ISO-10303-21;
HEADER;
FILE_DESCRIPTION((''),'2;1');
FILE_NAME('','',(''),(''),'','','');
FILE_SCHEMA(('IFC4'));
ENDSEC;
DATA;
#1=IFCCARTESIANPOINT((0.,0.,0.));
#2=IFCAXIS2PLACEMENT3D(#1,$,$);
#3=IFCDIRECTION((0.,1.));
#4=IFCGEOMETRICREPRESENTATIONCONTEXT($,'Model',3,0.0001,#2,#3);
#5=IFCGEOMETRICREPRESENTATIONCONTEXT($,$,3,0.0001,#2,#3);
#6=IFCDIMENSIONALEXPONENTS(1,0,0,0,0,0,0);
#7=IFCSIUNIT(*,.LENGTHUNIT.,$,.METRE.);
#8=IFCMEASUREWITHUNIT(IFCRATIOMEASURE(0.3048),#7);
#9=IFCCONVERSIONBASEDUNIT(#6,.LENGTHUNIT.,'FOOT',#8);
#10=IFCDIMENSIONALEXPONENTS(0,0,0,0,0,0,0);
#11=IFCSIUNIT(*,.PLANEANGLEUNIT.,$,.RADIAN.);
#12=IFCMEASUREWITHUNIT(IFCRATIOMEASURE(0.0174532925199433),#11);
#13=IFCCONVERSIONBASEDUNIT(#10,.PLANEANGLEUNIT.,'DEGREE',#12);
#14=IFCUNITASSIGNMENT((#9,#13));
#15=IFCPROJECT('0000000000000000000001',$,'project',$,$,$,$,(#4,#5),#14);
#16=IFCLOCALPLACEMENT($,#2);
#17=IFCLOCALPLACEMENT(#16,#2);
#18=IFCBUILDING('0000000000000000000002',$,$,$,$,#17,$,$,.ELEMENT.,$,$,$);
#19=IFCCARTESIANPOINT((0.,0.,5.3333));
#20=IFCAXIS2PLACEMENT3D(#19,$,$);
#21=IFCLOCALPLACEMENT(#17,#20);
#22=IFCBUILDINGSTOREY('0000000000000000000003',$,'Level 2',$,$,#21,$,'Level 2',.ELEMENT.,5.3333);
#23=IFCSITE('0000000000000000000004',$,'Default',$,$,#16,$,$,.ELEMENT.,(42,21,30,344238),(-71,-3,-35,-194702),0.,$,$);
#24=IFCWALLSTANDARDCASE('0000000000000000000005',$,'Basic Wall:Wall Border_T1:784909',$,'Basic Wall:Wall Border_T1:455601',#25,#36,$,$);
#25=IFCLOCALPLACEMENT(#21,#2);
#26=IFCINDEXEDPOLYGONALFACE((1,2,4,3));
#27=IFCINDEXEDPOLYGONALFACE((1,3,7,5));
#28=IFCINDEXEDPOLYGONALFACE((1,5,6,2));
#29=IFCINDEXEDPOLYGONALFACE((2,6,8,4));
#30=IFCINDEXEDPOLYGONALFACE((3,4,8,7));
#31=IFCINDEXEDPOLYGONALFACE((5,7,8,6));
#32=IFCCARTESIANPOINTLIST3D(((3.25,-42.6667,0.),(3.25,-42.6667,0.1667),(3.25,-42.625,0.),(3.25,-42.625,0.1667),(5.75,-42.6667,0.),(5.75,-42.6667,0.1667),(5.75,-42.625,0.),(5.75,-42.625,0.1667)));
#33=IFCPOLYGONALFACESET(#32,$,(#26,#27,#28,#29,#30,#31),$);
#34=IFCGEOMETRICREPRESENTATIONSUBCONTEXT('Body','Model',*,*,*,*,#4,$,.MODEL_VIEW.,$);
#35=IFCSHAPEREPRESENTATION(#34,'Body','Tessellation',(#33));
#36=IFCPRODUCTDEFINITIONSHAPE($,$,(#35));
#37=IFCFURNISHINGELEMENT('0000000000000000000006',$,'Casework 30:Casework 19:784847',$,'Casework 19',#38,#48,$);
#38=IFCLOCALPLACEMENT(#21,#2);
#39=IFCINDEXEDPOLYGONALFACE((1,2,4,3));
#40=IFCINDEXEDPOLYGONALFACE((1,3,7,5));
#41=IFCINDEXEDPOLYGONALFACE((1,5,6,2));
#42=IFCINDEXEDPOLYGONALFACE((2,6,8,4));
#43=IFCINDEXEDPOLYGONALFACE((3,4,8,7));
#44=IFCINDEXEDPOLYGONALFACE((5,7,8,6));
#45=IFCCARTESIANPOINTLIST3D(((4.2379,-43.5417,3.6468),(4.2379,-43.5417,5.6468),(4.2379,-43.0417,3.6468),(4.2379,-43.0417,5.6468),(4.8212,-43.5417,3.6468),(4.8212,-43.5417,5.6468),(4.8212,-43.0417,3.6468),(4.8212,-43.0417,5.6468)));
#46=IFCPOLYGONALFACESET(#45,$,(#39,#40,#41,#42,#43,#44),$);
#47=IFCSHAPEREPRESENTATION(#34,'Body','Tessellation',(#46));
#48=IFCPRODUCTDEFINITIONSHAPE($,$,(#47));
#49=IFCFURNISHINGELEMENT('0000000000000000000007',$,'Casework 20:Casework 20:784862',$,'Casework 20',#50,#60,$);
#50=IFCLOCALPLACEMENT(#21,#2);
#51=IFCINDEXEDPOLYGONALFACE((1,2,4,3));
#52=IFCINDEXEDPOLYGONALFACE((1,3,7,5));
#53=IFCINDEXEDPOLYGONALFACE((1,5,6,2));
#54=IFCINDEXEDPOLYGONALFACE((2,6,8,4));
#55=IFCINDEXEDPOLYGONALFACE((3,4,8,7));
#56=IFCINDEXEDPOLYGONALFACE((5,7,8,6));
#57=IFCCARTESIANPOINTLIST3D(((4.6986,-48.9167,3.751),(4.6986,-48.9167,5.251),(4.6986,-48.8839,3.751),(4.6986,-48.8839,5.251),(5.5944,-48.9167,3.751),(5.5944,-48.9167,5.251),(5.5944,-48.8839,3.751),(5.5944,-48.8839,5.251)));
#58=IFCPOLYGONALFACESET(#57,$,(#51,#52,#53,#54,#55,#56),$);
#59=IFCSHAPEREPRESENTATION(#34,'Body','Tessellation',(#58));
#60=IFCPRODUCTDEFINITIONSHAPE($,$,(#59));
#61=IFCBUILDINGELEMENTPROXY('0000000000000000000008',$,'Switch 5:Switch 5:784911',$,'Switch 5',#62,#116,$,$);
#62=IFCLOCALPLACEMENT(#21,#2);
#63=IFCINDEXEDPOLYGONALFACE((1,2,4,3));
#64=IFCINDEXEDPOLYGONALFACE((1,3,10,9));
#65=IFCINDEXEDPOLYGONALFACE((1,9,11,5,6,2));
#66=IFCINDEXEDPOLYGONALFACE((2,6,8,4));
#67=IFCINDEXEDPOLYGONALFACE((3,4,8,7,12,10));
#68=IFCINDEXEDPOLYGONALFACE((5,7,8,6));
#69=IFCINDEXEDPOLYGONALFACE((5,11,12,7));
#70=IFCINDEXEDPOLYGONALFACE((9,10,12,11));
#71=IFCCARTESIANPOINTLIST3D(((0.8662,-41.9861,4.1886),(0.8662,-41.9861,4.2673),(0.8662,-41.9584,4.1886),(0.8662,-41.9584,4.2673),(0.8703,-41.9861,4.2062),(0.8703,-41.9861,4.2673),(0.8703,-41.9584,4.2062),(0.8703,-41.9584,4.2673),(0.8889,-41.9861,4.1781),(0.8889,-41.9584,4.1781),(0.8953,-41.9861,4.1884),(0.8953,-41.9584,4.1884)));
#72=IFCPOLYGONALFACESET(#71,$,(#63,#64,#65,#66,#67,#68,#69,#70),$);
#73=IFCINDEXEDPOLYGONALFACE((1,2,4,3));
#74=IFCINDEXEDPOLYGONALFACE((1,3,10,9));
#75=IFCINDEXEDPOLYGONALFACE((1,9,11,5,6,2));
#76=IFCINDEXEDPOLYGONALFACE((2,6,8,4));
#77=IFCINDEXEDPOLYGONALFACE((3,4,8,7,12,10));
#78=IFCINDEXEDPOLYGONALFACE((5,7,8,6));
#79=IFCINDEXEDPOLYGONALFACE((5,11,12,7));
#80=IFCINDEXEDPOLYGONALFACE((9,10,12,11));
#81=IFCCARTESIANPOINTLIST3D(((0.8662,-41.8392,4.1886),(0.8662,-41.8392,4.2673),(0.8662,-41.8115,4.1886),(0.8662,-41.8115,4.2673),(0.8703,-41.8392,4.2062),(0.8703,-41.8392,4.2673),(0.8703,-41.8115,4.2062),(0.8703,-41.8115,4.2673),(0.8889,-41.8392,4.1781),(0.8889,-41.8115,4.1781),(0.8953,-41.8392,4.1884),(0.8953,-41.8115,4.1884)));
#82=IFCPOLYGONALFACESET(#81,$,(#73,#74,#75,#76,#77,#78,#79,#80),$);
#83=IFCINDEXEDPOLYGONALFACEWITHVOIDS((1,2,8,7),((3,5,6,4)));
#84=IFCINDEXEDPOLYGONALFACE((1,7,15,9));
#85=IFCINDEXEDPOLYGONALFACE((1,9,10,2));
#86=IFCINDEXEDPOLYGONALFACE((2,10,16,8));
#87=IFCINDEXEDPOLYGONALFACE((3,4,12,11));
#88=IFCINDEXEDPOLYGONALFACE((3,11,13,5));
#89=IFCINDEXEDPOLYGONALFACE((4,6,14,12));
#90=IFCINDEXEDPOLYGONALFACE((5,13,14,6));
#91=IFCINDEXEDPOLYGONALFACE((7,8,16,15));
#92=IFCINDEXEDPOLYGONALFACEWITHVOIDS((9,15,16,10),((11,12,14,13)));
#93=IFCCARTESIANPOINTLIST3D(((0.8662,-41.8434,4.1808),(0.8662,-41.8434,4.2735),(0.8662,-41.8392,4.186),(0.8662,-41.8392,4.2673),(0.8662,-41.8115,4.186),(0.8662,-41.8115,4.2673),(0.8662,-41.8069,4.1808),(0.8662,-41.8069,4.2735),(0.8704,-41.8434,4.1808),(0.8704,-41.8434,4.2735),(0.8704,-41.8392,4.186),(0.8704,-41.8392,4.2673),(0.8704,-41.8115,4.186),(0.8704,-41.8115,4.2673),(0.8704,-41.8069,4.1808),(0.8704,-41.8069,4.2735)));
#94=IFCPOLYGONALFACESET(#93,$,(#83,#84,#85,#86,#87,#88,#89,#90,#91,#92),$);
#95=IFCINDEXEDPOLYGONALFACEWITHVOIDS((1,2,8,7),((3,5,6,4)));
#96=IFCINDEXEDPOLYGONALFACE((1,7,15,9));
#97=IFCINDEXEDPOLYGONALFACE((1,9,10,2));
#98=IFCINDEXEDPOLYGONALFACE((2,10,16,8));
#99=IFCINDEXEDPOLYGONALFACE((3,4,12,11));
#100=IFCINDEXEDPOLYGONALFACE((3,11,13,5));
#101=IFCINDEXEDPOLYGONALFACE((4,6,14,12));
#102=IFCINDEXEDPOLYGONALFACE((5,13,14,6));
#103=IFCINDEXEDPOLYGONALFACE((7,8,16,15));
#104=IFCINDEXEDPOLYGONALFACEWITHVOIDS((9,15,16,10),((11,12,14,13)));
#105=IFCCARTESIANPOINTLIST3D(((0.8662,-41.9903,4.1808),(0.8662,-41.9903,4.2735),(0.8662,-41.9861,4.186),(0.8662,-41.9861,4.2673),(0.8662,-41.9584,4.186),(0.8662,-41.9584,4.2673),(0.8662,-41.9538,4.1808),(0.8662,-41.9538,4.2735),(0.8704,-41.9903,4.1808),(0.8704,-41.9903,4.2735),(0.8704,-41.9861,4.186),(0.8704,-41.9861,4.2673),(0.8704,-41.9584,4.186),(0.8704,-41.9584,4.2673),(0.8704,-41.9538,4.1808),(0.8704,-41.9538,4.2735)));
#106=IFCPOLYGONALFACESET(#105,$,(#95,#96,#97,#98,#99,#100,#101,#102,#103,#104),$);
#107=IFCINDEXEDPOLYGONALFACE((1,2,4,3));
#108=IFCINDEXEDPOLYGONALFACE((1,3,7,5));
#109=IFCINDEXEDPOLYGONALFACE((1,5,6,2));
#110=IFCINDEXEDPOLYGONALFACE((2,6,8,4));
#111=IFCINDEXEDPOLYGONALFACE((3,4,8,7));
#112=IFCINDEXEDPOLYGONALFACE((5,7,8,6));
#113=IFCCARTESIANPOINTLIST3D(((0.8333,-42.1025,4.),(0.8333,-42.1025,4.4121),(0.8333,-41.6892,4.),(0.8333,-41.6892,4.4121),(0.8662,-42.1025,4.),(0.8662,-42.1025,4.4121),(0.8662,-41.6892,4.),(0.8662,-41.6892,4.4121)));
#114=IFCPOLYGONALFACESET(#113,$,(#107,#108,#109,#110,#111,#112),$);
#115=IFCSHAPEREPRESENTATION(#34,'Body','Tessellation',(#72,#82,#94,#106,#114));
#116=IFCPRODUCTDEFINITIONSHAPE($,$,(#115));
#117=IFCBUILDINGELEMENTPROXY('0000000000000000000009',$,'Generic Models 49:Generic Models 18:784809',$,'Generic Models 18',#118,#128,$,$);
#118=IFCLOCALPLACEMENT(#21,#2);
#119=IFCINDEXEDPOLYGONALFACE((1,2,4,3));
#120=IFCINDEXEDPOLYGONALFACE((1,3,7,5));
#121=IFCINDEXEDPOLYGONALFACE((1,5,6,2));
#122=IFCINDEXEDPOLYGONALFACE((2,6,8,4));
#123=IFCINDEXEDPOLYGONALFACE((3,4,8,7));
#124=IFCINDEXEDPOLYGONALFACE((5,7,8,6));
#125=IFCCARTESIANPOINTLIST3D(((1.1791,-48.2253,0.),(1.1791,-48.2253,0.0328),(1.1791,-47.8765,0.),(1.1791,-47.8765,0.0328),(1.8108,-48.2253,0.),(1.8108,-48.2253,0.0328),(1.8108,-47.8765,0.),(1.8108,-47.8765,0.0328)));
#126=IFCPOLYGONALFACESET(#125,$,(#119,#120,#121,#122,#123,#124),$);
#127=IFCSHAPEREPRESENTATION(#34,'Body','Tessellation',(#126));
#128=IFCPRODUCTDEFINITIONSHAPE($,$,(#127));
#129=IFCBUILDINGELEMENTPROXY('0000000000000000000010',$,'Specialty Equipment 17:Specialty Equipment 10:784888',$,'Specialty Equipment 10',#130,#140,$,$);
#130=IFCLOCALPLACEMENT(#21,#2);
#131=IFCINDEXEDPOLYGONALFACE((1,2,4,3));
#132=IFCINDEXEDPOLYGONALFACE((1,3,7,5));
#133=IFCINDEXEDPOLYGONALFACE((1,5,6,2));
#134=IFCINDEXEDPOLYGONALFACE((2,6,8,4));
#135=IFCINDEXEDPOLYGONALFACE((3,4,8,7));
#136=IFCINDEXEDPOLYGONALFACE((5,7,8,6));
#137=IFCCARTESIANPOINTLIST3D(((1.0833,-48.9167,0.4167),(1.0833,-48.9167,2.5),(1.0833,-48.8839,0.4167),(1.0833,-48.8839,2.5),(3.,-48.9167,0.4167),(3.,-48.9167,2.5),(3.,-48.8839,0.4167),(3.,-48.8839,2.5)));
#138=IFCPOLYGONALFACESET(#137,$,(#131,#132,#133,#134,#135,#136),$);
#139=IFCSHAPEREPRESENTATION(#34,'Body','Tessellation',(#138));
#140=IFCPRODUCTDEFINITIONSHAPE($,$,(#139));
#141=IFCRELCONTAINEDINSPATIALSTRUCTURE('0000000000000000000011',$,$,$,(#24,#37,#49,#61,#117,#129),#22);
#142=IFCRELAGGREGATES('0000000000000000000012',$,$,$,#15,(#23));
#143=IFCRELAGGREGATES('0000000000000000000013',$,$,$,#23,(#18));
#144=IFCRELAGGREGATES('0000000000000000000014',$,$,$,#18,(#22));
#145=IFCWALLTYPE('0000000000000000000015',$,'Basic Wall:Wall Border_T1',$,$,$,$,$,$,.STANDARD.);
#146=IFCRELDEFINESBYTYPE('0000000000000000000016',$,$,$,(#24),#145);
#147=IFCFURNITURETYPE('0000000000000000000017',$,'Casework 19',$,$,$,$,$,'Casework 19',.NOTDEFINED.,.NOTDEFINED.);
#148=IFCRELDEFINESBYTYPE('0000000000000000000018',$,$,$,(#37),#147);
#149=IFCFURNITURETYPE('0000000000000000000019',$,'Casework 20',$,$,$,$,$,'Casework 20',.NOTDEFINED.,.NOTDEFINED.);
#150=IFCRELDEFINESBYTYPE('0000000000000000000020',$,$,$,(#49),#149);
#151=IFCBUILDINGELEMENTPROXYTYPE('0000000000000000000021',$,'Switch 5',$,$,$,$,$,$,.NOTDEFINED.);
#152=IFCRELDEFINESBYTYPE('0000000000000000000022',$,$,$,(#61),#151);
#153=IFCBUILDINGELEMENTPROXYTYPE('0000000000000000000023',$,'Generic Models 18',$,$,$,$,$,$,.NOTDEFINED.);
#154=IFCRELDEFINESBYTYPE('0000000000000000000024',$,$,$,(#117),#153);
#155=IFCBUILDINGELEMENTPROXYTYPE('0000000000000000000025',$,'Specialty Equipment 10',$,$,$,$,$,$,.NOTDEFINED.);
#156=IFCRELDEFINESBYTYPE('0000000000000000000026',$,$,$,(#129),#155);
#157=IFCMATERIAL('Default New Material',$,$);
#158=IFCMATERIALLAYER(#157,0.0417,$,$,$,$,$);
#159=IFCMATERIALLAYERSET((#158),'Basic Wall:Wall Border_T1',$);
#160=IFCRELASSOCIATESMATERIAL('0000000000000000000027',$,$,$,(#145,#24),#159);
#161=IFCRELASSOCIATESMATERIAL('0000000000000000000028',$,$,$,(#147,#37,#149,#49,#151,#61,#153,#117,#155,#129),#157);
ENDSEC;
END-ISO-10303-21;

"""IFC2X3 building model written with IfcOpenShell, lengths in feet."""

from ifc_helpers import new_model, entity, si_unit, converted_unit, direction, frame, frame_2d, origin, origin_2d_with_axis, place, context, subcontext, project, spatial, polyline, rectangle, outline, extrude, source, transform, mapped, material, layer, layer_set, layer_usage, type_object, type_shapes, element, save


model = new_model("IFC2X3")

# Units and contexts
model_context = context("Model", 3, precision=0.0001, world=origin(), true_north=direction((0.0, 1.0)))
context_of_model = context(None, 3, precision=0.0001, world=origin(), true_north=direction((0.0, 1.0)))
body_context = subcontext(model_context, "Body", "Model", "MODEL_VIEW")
ifc_project = project(units=[converted_unit("LENGTHUNIT", "FOOT", entity("IfcRatioMeasure", 0.3048), si_unit("LENGTHUNIT", "METRE"), dimensions=[1, 0, 0, 0, 0, 0, 0]), converted_unit("PLANEANGLEUNIT", "DEGREE", entity("IfcRatioMeasure", 0.0174532925199433), si_unit("PLANEANGLEUNIT", "RADIAN"), dimensions=[0, 0, 0, 0, 0, 0, 0])], contexts=[model_context, context_of_model])

# Site, building, storey
site_placement = place(None, origin())
site = spatial("IfcSite", under=ifc_project, at=site_placement, Name="Default", CompositionType="ELEMENT", RefLatitude=(42, 21, 30, 344238), RefLongitude=(-71, -3, -35, -194702), RefElevation=0.0)
building_placement = place(site_placement, origin())
building = spatial("IfcBuilding", under=site, at=building_placement, CompositionType="ELEMENT")
storey_placement = place(building_placement, frame((0.0, 0.0, 5.3333)))
storey = spatial("IfcBuildingStorey", under=building, at=storey_placement, Name="Level 2", LongName="Level 2", CompositionType="ELEMENT", Elevation=5.3333)

# Shared definitions
ifc_material = material(Name="Default New Material")

# Wall
ifc_layer_1 = layer(ifc_material, 0.0417)
ifc_layer_set_1 = layer_set([ifc_layer_1], Name="Basic Wall:Wall Border_T1")
wall_type_1 = type_object("IfcWallType", Name="Basic Wall:Wall Border_T1", PredefinedType="STANDARD", material=ifc_layer_set_1)
ifc_layer_usage_1 = layer_usage(ifc_layer_set_1, "AXIS2", "POSITIVE", -0.0208)
wall_1_placement = place(storey_placement, frame((5.75, -42.6458, 0.0), z_axis=(0.0, 0.0, 1.0), x_axis=(-1.0, 0.0, 0.0)))
element("IfcWallStandardCase", 1, at=wall_1_placement, inside=storey, type_object=wall_type_1, material=ifc_layer_usage_1, Name="Basic Wall:Wall Border_T1:784909", ObjectType="Basic Wall:Wall Border_T1:455601", context=body_context, shape_type="SweptSolid", body=[
    extrude(rectangle(XDim=2.5, YDim=0.0417, at=frame_2d((1.25, 0.0), x_axis=(-1.0, 0.0))), origin(), (0.0, 0.0, 1.0), 0.1667),
])

# Furnishing elements
furniture_type_1 = type_object("IfcFurnitureType", Name="Casework 19", ElementType="Casework 19", AssemblyPlace="NOTDEFINED", material=ifc_material)
shared_shape_1 = source(origin(), body_context, "Body", "SweptSolid", [
    extrude(rectangle(XDim=0.5, YDim=0.5833, at=origin_2d_with_axis()), frame((0.2917, 0.25, 0.0), z_axis=(0.0, 0.0, 1.0), x_axis=(0.0, 1.0, 0.0)), (0.0, 0.0, 1.0), 2.0),
])
type_shapes(furniture_type_1, [shared_shape_1])
furnishing_1_placement = place(storey_placement, frame((4.2379, -43.5417, 3.6468)))
element("IfcFurnishingElement", 2, at=furnishing_1_placement, inside=storey, type_object=furniture_type_1, material=ifc_material, Name="Casework 30:Casework 19:784847", ObjectType="Casework 19", context=body_context, shape_type="MappedRepresentation", body=[
    mapped(shared_shape_1, transform((0.0, 0.0, 0.0), scale=1.0)),
])
furniture_type_2 = type_object("IfcFurnitureType", Name="Casework 20", ElementType="Casework 20", AssemblyPlace="NOTDEFINED", material=ifc_material)
shared_shape_2 = source(origin(), body_context, "Body", "SweptSolid", [
    extrude(rectangle(XDim=0.0328, YDim=0.8958, at=frame_2d((0.0, 0.0), x_axis=(1.0, 0.0))), frame((0.4479, 0.0164, 0.0), z_axis=(0.0, 0.0, 1.0), x_axis=(0.0, -1.0, 0.0)), (0.0, 0.0, 1.0), 1.5),
])
type_shapes(furniture_type_2, [shared_shape_2])
furnishing_2_placement = place(storey_placement, frame((4.6986, -48.9167, 3.751)))
element("IfcFurnishingElement", 3, at=furnishing_2_placement, inside=storey, type_object=furniture_type_2, material=ifc_material, Name="Casework 20:Casework 20:784862", ObjectType="Casework 20", context=body_context, shape_type="MappedRepresentation", body=[
    mapped(shared_shape_2, transform((0.0, 0.0, 0.0), scale=1.0)),
])

# Building element proxies
building_element_proxy_type_1 = type_object("IfcBuildingElementProxyType", Name="Switch 5", PredefinedType="NOTDEFINED", material=ifc_material)
shared_shape_3 = source(origin(), body_context, "Body", "SweptSolid", [
    extrude(outline(polyline([(-0.0255, -0.0308), (-0.0133, -0.0308), (-0.0115, -0.0002), (0.0405, 0.0322), (0.0383, 0.0356), (-0.0285, -0.006), (-0.0255, -0.0308)])), frame((0.0626, 0.0429, 0.216), z_axis=(1.0, 0.0, 0.0), x_axis=(0.0, 0.528865, 0.848706)), (0.0, 0.0, 1.0), 0.0277),
    extrude(outline(polyline([(-0.0255, -0.0308), (-0.0133, -0.0308), (-0.0115, -0.0002), (0.0405, 0.0322), (0.0383, 0.0356), (-0.0285, -0.006), (-0.0255, -0.0308)])), frame((-0.0843, 0.0429, 0.216), z_axis=(1.0, 0.0, 0.0), x_axis=(0.0, 0.528865, 0.848706)), (0.0, 0.0, 1.0), 0.0277),
    extrude(outline(polyline([(-0.0464, -0.0182), (0.0464, -0.0182), (0.0464, 0.0182), (-0.0464, 0.0182), (-0.0464, -0.0182)]), holes=[polyline([(-0.0402, -0.0141), (-0.0402, 0.0136), (0.0411, 0.0136), (0.0411, -0.0141), (-0.0402, -0.0141)])]), frame((-0.0707, 0.0329, 0.2271), z_axis=(0.0, 1.0, 0.0), x_axis=(0.0, 0.0, -1.0)), (0.0, 0.0, 1.0), 0.0042),
    extrude(outline(polyline([(-0.0464, -0.0182), (0.0464, -0.0182), (0.0464, 0.0182), (-0.0464, 0.0182), (-0.0464, -0.0182)]), holes=[polyline([(-0.0402, -0.0141), (-0.0402, 0.0136), (0.0411, 0.0136), (0.0411, -0.0141), (-0.0402, -0.0141)])]), frame((0.0762, 0.0329, 0.2271), z_axis=(0.0, 1.0, 0.0), x_axis=(0.0, 0.0, -1.0)), (0.0, 0.0, 1.0), 0.0042),
    extrude(rectangle(XDim=0.0329, YDim=0.4134, at=origin_2d_with_axis()), frame((0.0, 0.0164, 0.0), z_axis=(0.0, 0.0, 1.0), x_axis=(0.0, -1.0, 0.0)), (0.0, 0.0, 1.0), 0.4121),
])
type_shapes(building_element_proxy_type_1, [shared_shape_3])
proxy_1_placement = place(storey_placement, frame((0.8333, -41.8958, 4.0), z_axis=(0.0, 0.0, 1.0), x_axis=(0.0, -1.0, 0.0)))
element("IfcBuildingElementProxy", 4, at=proxy_1_placement, inside=storey, type_object=building_element_proxy_type_1, material=ifc_material, Name="Switch 5:Switch 5:784911", ObjectType="Switch 5", context=body_context, shape_type="MappedRepresentation", body=[
    mapped(shared_shape_3, transform((0.0, 0.0, 0.0), scale=1.0)),
])
building_element_proxy_type_2 = type_object("IfcBuildingElementProxyType", Name="Generic Models 18", PredefinedType="NOTDEFINED", material=ifc_material)
shared_shape_4 = source(origin(), body_context, "Body", "SweptSolid", [
    extrude(rectangle(XDim=0.3488, YDim=0.6317, at=frame_2d((0.0, 0.0), x_axis=(1.0, 0.0))), frame((0.3159, 0.1744, 0.0), z_axis=(0.0, 0.0, 1.0), x_axis=(0.0, -1.0, 0.0)), (0.0, 0.0, 1.0), 0.0328),
])
type_shapes(building_element_proxy_type_2, [shared_shape_4])
proxy_2_placement = place(storey_placement, frame((1.1791, -48.2253, 0.0)))
element("IfcBuildingElementProxy", 5, at=proxy_2_placement, inside=storey, type_object=building_element_proxy_type_2, material=ifc_material, Name="Generic Models 49:Generic Models 18:784809", ObjectType="Generic Models 18", context=body_context, shape_type="MappedRepresentation", body=[
    mapped(shared_shape_4, transform((0.0, 0.0, 0.0), scale=1.0)),
])
building_element_proxy_type_3 = type_object("IfcBuildingElementProxyType", Name="Specialty Equipment 10", PredefinedType="NOTDEFINED", material=ifc_material)
shared_shape_5 = source(origin(), body_context, "Body", "SweptSolid", [
    extrude(rectangle(XDim=0.0328, YDim=1.9167, at=frame_2d((0.0, 0.0), x_axis=(1.0, 0.0))), frame((0.9583, 0.0164, 0.0), z_axis=(0.0, 0.0, 1.0), x_axis=(0.0, -1.0, 0.0)), (0.0, 0.0, 1.0), 2.0833),
])
type_shapes(building_element_proxy_type_3, [shared_shape_5])
proxy_3_placement = place(storey_placement, frame((1.0833, -48.9167, 0.4167)))
element("IfcBuildingElementProxy", 6, at=proxy_3_placement, inside=storey, type_object=building_element_proxy_type_3, material=ifc_material, Name="Specialty Equipment 17:Specialty Equipment 10:784888", ObjectType="Specialty Equipment 10", context=body_context, shape_type="MappedRepresentation", body=[
    mapped(shared_shape_5, transform((0.0, 0.0, 0.0), scale=1.0)),
])

save(model, "model.ifc")
